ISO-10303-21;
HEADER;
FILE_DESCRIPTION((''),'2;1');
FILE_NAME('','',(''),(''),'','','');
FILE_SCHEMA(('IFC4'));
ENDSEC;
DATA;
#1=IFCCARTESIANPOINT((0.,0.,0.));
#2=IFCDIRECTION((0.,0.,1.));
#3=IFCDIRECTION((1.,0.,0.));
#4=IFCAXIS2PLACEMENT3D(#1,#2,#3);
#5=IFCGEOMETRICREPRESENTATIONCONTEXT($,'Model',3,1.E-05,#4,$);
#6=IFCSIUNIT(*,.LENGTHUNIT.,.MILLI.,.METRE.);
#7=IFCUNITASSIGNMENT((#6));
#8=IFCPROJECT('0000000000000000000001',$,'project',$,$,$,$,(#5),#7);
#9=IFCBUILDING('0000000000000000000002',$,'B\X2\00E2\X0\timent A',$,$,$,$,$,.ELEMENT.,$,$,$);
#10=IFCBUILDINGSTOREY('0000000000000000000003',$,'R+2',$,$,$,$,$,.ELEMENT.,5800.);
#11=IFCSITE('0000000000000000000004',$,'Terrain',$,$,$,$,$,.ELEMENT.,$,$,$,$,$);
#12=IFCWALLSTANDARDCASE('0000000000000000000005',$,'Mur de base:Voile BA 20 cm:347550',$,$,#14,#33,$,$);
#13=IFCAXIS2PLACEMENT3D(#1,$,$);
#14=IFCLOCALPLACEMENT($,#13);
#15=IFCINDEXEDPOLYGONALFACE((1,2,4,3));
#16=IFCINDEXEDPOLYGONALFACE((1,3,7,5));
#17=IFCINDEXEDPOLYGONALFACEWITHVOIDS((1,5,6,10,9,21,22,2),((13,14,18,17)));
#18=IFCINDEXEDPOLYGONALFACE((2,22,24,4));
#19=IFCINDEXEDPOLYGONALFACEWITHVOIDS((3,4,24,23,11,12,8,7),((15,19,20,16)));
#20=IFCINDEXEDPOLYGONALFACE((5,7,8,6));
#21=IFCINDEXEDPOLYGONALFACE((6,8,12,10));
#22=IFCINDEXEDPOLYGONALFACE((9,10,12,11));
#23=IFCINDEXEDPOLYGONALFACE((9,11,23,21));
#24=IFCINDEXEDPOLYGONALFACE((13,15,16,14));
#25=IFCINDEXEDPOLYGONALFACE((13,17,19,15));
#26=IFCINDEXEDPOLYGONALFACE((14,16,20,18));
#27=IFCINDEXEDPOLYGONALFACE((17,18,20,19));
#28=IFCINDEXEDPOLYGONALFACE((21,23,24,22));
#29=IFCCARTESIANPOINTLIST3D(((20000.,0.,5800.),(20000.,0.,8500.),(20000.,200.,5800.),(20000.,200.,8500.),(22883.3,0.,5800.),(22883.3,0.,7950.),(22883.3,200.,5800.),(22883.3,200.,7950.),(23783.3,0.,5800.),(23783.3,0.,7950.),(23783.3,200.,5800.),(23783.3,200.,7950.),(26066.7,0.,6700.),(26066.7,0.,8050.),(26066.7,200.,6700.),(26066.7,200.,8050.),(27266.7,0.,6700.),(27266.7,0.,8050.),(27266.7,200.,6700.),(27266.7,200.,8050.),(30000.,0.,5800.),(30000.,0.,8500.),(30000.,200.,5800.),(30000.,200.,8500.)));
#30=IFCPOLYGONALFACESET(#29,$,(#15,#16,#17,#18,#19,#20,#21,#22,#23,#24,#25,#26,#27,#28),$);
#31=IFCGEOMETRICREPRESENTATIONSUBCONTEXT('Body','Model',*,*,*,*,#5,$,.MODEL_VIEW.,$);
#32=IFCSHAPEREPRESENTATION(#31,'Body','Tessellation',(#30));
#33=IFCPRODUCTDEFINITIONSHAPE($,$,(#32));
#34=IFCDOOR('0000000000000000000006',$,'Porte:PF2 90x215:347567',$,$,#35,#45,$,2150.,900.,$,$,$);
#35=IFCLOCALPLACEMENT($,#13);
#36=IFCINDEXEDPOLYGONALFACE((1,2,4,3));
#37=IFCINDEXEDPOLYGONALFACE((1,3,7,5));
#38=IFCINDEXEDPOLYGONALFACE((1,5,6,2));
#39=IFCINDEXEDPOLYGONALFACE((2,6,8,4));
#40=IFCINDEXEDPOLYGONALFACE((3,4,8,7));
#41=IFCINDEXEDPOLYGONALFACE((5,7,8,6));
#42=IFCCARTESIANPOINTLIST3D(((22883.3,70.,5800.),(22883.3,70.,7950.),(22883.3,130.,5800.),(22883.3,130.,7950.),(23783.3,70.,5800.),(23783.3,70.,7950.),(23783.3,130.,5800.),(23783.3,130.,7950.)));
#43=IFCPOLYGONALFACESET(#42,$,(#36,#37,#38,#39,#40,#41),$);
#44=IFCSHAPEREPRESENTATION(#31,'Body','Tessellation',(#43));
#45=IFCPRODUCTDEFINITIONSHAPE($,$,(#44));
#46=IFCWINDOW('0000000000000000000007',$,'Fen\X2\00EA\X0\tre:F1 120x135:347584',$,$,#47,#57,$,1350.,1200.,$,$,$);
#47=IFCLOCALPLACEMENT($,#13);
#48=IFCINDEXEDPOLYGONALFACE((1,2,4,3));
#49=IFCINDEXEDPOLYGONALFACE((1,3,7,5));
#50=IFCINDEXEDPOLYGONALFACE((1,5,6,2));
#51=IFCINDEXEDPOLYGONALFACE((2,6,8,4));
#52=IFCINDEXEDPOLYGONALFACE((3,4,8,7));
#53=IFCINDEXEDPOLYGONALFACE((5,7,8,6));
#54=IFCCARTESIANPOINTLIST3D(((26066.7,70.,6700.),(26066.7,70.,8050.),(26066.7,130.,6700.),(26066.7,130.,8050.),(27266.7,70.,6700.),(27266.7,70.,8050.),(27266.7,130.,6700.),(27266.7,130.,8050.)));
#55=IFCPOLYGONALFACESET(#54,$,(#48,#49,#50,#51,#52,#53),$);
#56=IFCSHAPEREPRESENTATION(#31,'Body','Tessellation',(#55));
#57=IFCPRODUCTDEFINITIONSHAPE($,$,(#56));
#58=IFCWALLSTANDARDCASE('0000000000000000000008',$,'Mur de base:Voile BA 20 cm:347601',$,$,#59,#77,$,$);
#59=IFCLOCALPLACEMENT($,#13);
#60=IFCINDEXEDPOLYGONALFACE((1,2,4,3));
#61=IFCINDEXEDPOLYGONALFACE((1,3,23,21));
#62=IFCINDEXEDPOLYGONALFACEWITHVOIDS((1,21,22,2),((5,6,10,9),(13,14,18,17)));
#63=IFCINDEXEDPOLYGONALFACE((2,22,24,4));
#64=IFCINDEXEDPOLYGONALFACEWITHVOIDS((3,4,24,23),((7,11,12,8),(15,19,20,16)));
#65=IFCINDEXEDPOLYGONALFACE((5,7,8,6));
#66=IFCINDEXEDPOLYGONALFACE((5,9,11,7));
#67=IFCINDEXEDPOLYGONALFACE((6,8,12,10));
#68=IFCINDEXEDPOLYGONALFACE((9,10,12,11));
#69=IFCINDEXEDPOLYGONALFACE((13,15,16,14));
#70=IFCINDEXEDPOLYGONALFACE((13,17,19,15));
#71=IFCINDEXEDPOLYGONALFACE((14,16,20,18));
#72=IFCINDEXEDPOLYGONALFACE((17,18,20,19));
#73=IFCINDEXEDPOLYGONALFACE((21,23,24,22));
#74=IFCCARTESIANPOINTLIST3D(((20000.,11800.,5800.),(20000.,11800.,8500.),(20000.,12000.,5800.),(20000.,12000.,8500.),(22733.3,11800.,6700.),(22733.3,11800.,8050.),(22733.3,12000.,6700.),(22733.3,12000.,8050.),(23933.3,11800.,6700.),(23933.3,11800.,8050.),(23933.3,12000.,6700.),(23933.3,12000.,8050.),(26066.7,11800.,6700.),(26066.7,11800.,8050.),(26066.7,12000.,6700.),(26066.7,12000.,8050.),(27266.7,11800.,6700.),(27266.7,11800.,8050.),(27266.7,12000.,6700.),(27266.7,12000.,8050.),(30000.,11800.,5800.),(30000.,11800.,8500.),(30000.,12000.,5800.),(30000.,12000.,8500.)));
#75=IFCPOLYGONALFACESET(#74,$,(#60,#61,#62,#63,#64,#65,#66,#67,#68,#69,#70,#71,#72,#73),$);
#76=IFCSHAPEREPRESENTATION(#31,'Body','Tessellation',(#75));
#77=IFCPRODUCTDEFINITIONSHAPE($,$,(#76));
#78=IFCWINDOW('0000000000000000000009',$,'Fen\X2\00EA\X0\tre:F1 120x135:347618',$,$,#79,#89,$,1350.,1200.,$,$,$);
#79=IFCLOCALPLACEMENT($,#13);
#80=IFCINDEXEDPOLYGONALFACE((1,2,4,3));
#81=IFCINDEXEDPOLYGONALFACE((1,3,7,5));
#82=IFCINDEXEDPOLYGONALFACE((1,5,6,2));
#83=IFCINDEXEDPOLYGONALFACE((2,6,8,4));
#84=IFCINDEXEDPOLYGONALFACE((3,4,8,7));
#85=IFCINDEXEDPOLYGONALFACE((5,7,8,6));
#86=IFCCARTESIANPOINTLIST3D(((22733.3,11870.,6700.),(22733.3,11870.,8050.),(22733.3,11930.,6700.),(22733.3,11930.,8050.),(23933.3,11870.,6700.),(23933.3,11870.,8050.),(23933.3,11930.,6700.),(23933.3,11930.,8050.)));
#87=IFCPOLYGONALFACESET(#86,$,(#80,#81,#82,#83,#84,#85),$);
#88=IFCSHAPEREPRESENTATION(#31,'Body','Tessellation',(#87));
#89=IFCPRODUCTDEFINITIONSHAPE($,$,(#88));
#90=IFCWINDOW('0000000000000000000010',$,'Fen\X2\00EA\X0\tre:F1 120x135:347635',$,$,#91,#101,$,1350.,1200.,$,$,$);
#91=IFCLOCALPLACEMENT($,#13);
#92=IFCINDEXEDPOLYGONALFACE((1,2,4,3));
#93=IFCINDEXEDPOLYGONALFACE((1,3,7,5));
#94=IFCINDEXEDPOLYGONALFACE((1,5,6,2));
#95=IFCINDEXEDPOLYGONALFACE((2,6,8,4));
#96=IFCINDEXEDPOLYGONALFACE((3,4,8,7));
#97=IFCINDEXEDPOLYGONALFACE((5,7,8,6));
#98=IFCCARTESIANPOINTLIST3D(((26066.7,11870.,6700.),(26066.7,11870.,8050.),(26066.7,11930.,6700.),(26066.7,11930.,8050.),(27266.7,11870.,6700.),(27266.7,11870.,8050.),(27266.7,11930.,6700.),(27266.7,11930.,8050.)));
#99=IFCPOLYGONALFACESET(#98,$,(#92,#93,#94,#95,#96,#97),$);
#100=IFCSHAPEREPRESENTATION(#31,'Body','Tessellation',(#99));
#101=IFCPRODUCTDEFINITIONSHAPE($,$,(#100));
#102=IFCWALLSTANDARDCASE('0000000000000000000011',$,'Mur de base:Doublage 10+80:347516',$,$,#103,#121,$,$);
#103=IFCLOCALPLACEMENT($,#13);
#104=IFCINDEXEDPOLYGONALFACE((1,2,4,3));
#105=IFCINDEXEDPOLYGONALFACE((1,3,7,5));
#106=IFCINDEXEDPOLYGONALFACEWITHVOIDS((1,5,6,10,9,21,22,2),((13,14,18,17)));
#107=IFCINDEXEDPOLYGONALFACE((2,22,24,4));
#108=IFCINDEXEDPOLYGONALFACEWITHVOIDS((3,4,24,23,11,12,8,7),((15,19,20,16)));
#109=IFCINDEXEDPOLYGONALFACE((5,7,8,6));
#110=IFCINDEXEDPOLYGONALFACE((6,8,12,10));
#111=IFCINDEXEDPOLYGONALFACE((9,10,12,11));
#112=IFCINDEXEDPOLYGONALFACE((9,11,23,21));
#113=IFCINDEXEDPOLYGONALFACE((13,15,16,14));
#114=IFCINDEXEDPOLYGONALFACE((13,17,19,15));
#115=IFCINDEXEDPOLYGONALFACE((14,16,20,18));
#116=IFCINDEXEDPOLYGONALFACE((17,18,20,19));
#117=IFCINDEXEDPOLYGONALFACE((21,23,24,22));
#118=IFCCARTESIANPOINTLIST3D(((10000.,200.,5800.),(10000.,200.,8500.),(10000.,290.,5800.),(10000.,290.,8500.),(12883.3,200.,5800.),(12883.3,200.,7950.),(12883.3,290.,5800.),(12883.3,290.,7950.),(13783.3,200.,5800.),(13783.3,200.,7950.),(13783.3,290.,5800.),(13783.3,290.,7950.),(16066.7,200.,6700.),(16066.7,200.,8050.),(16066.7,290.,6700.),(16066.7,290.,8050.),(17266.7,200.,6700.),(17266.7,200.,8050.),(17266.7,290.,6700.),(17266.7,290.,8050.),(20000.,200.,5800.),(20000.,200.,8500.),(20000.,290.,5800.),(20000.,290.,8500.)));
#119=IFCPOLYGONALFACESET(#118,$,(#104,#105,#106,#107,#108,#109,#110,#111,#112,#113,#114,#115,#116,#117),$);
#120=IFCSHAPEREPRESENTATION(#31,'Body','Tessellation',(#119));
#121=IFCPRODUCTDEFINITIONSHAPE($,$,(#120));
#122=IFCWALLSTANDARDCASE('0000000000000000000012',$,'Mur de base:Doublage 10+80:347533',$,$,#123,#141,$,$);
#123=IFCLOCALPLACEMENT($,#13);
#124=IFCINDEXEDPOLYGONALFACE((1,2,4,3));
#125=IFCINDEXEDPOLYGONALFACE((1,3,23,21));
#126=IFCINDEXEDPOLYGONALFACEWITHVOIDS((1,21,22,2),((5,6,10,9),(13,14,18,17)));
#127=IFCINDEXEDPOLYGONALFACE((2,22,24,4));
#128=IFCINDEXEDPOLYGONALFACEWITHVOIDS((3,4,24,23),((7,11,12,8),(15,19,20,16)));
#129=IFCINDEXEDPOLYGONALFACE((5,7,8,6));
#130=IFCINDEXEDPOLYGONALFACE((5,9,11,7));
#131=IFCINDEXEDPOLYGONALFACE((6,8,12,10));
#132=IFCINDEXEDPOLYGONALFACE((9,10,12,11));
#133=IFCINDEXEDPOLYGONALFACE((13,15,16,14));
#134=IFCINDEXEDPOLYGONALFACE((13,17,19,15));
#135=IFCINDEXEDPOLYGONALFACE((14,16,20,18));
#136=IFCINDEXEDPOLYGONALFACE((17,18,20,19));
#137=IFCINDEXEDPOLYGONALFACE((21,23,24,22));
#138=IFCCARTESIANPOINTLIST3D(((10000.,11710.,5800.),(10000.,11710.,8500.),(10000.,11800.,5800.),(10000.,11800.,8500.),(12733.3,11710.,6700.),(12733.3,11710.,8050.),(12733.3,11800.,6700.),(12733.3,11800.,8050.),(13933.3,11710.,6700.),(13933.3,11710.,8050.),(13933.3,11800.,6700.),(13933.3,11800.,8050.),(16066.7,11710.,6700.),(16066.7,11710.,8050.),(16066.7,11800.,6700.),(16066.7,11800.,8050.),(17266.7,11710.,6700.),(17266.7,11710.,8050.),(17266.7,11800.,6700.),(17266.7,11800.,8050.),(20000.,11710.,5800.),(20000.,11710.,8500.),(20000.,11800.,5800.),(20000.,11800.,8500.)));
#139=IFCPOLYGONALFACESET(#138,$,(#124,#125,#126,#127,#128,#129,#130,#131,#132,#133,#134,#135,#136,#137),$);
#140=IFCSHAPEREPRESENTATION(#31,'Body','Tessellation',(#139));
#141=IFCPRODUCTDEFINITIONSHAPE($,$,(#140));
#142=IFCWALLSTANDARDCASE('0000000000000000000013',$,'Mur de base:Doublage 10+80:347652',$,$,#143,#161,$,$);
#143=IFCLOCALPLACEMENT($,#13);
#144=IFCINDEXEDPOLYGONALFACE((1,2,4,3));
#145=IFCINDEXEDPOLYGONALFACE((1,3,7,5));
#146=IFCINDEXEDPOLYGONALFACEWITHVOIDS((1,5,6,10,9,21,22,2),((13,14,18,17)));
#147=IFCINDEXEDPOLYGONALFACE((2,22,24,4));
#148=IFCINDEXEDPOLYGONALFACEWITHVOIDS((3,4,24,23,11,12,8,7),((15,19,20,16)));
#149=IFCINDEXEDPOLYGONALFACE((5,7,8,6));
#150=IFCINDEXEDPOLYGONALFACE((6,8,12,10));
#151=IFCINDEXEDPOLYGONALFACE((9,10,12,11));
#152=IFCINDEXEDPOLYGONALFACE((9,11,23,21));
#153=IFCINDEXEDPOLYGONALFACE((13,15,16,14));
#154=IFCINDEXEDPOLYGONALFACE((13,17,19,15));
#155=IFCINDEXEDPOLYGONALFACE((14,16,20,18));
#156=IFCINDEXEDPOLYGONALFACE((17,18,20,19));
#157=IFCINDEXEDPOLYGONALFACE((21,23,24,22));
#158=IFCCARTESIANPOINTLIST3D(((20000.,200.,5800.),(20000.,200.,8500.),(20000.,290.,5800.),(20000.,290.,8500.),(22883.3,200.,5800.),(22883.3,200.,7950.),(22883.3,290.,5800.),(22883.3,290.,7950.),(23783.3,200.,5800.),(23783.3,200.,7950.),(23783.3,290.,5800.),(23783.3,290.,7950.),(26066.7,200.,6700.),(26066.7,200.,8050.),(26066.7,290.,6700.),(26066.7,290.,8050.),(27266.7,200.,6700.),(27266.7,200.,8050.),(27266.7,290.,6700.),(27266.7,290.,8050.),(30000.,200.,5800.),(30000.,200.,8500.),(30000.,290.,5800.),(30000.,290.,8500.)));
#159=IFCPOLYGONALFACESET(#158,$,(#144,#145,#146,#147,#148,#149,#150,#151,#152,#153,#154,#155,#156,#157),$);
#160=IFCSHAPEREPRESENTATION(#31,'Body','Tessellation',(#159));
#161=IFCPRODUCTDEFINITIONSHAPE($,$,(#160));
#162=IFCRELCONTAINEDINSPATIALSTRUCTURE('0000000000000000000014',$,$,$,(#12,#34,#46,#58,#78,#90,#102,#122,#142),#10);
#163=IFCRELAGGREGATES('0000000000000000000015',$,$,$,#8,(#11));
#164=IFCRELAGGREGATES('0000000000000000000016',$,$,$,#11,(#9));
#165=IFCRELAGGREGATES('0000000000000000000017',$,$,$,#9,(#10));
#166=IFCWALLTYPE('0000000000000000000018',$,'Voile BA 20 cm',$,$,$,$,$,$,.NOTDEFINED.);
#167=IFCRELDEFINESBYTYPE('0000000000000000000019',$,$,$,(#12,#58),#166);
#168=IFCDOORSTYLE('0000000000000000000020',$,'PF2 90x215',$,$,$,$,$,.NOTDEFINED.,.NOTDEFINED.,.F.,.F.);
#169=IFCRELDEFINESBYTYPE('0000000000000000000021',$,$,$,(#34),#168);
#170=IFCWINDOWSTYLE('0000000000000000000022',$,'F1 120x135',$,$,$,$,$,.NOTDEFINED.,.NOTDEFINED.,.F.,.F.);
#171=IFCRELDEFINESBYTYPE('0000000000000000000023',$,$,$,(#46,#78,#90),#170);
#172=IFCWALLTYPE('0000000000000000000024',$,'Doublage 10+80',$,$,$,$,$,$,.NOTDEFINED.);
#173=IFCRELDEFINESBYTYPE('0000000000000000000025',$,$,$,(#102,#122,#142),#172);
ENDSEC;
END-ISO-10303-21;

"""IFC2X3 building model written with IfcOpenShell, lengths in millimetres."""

from ifc_helpers import new_model, si_unit, frame, frame_2d, origin_with_axes, place, context, subcontext, project, spatial, rectangle, extrude, type_object, element, fill, save


model = new_model("IFC2X3")

# Units and contexts
model_context = context("Model", 3, precision=1e-05, world=origin_with_axes())
body_context = subcontext(model_context, "Body", "Model", "MODEL_VIEW")
ifc_project = project(units=[si_unit("LENGTHUNIT", "METRE", prefix="MILLI")], contexts=[model_context])

# Site, building, storey
site = spatial("IfcSite", under=ifc_project, Name="Terrain", CompositionType="ELEMENT")
building = spatial("IfcBuilding", under=site, Name="Bâtiment A", CompositionType="ELEMENT")
storey = spatial("IfcBuildingStorey", under=building, Name="R+2", CompositionType="ELEMENT", Elevation=5800.0)

# Wall, openings, door, window
wall_type_1 = type_object("IfcWallType", Name="Voile BA 20 cm", PredefinedType="NOTDEFINED")
wall_1_placement = place(None, origin_with_axes())
wall_1 = element("IfcWallStandardCase", 1, at=wall_1_placement, inside=storey, type_object=wall_type_1, Name="Mur de base:Voile BA 20 cm:347550", context=body_context, shape_type="SweptSolid", body=[
    extrude(rectangle(XDim=10000.0, YDim=200.0, at=frame_2d((25000.0, 100.0))), frame((0.0, 0.0, 5800.0), z_axis=(0.0, 0.0, 1.0), x_axis=(1.0, 0.0, 0.0)), (0.0, 0.0, 1.0), 2700.0),
])
opening_1_placement = place(None, origin_with_axes())
opening_1 = element("IfcOpeningElement", 2, at=opening_1_placement, cuts=wall_1, context=body_context, shape_type="SweptSolid", body=[
    extrude(rectangle(XDim=900.0, YDim=320.0, at=frame_2d((23333.3, 100.0))), frame((0.0, 0.0, 5800.0), z_axis=(0.0, 0.0, 1.0), x_axis=(1.0, 0.0, 0.0)), (0.0, 0.0, 1.0), 2150.0),
])
opening_2_placement = place(None, origin_with_axes())
opening_2 = element("IfcOpeningElement", 3, at=opening_2_placement, cuts=wall_1, context=body_context, shape_type="SweptSolid", body=[
    extrude(rectangle(XDim=1200.0, YDim=320.0, at=frame_2d((26666.7, 100.0))), frame((0.0, 0.0, 6700.0), z_axis=(0.0, 0.0, 1.0), x_axis=(1.0, 0.0, 0.0)), (0.0, 0.0, 1.0), 1350.0),
])
door_style = type_object("IfcDoorStyle", Name="PF2 90x215", ConstructionType="NOTDEFINED", OperationType="NOTDEFINED", ParameterTakesPrecedence=False, Sizeable=False)
door_placement = place(None, origin_with_axes())
door = element("IfcDoor", 4, at=door_placement, inside=storey, type_object=door_style, Name="Porte:PF2 90x215:347567", OverallHeight=2150.0, OverallWidth=900.0, context=body_context, shape_type="SweptSolid", body=[
    extrude(rectangle(XDim=900.0, YDim=60.0, at=frame_2d((23333.3, 100.0))), frame((0.0, 0.0, 5800.0), z_axis=(0.0, 0.0, 1.0), x_axis=(1.0, 0.0, 0.0)), (0.0, 0.0, 1.0), 2150.0),
])
fill(opening_1, door)
window_style = type_object("IfcWindowStyle", Name="F1 120x135", ConstructionType="NOTDEFINED", OperationType="NOTDEFINED", ParameterTakesPrecedence=False, Sizeable=False)
window_1_placement = place(None, origin_with_axes())
window_1 = element("IfcWindow", 5, at=window_1_placement, inside=storey, type_object=window_style, Name="Fenêtre:F1 120x135:347584", OverallHeight=1350.0, OverallWidth=1200.0, context=body_context, shape_type="SweptSolid", body=[
    extrude(rectangle(XDim=1200.0, YDim=60.0, at=frame_2d((26666.7, 100.0))), frame((0.0, 0.0, 6700.0), z_axis=(0.0, 0.0, 1.0), x_axis=(1.0, 0.0, 0.0)), (0.0, 0.0, 1.0), 1350.0),
])
fill(opening_2, window_1)

# Wall, openings, windows
wall_2_placement = place(None, origin_with_axes())
wall_2 = element("IfcWallStandardCase", 6, at=wall_2_placement, inside=storey, type_object=wall_type_1, Name="Mur de base:Voile BA 20 cm:347601", context=body_context, shape_type="SweptSolid", body=[
    extrude(rectangle(XDim=10000.0, YDim=200.0, at=frame_2d((25000.0, 11900.0))), frame((0.0, 0.0, 5800.0), z_axis=(0.0, 0.0, 1.0), x_axis=(1.0, 0.0, 0.0)), (0.0, 0.0, 1.0), 2700.0),
])
opening_3_placement = place(None, origin_with_axes())
opening_3 = element("IfcOpeningElement", 7, at=opening_3_placement, cuts=wall_2, context=body_context, shape_type="SweptSolid", body=[
    extrude(rectangle(XDim=1200.0, YDim=320.0, at=frame_2d((23333.3, 11900.0))), frame((0.0, 0.0, 6700.0), z_axis=(0.0, 0.0, 1.0), x_axis=(1.0, 0.0, 0.0)), (0.0, 0.0, 1.0), 1350.0),
])
opening_4_placement = place(None, origin_with_axes())
opening_4 = element("IfcOpeningElement", 8, at=opening_4_placement, cuts=wall_2, context=body_context, shape_type="SweptSolid", body=[
    extrude(rectangle(XDim=1200.0, YDim=320.0, at=frame_2d((26666.7, 11900.0))), frame((0.0, 0.0, 6700.0), z_axis=(0.0, 0.0, 1.0), x_axis=(1.0, 0.0, 0.0)), (0.0, 0.0, 1.0), 1350.0),
])
window_2_placement = place(None, origin_with_axes())
window_2 = element("IfcWindow", 9, at=window_2_placement, inside=storey, type_object=window_style, Name="Fenêtre:F1 120x135:347618", OverallHeight=1350.0, OverallWidth=1200.0, context=body_context, shape_type="SweptSolid", body=[
    extrude(rectangle(XDim=1200.0, YDim=60.0, at=frame_2d((23333.3, 11900.0))), frame((0.0, 0.0, 6700.0), z_axis=(0.0, 0.0, 1.0), x_axis=(1.0, 0.0, 0.0)), (0.0, 0.0, 1.0), 1350.0),
])
fill(opening_3, window_2)
window_3_placement = place(None, origin_with_axes())
window_3 = element("IfcWindow", 10, at=window_3_placement, inside=storey, type_object=window_style, Name="Fenêtre:F1 120x135:347635", OverallHeight=1350.0, OverallWidth=1200.0, context=body_context, shape_type="SweptSolid", body=[
    extrude(rectangle(XDim=1200.0, YDim=60.0, at=frame_2d((26666.7, 11900.0))), frame((0.0, 0.0, 6700.0), z_axis=(0.0, 0.0, 1.0), x_axis=(1.0, 0.0, 0.0)), (0.0, 0.0, 1.0), 1350.0),
])
fill(opening_4, window_3)

# Walls, openings
wall_type_2 = type_object("IfcWallType", Name="Doublage 10+80", PredefinedType="NOTDEFINED")
wall_3_placement = place(None, origin_with_axes())
wall_3 = element("IfcWallStandardCase", 11, at=wall_3_placement, inside=storey, type_object=wall_type_2, Name="Mur de base:Doublage 10+80:347516", context=body_context, shape_type="SweptSolid", body=[
    extrude(rectangle(XDim=10000.0, YDim=90.0, at=frame_2d((15000.0, 245.0))), frame((0.0, 0.0, 5800.0), z_axis=(0.0, 0.0, 1.0), x_axis=(1.0, 0.0, 0.0)), (0.0, 0.0, 1.0), 2700.0),
])
opening_5_placement = place(None, origin_with_axes())
element("IfcOpeningElement", 12, at=opening_5_placement, cuts=wall_3, context=body_context, shape_type="SweptSolid", body=[
    extrude(rectangle(XDim=900.0, YDim=210.0, at=frame_2d((13333.3, 245.0))), frame((0.0, 0.0, 5800.0), z_axis=(0.0, 0.0, 1.0), x_axis=(1.0, 0.0, 0.0)), (0.0, 0.0, 1.0), 2150.0),
])
opening_6_placement = place(None, origin_with_axes())
element("IfcOpeningElement", 13, at=opening_6_placement, cuts=wall_3, context=body_context, shape_type="SweptSolid", body=[
    extrude(rectangle(XDim=1200.0, YDim=210.0, at=frame_2d((16666.7, 245.0))), frame((0.0, 0.0, 6700.0), z_axis=(0.0, 0.0, 1.0), x_axis=(1.0, 0.0, 0.0)), (0.0, 0.0, 1.0), 1350.0),
])
wall_4_placement = place(None, origin_with_axes())
wall_4 = element("IfcWallStandardCase", 14, at=wall_4_placement, inside=storey, type_object=wall_type_2, Name="Mur de base:Doublage 10+80:347533", context=body_context, shape_type="SweptSolid", body=[
    extrude(rectangle(XDim=10000.0, YDim=90.0, at=frame_2d((15000.0, 11755.0))), frame((0.0, 0.0, 5800.0), z_axis=(0.0, 0.0, 1.0), x_axis=(1.0, 0.0, 0.0)), (0.0, 0.0, 1.0), 2700.0),
])
opening_7_placement = place(None, origin_with_axes())
element("IfcOpeningElement", 15, at=opening_7_placement, cuts=wall_4, context=body_context, shape_type="SweptSolid", body=[
    extrude(rectangle(XDim=1200.0, YDim=210.0, at=frame_2d((13333.3, 11755.0))), frame((0.0, 0.0, 6700.0), z_axis=(0.0, 0.0, 1.0), x_axis=(1.0, 0.0, 0.0)), (0.0, 0.0, 1.0), 1350.0),
])
opening_8_placement = place(None, origin_with_axes())
element("IfcOpeningElement", 16, at=opening_8_placement, cuts=wall_4, context=body_context, shape_type="SweptSolid", body=[
    extrude(rectangle(XDim=1200.0, YDim=210.0, at=frame_2d((16666.7, 11755.0))), frame((0.0, 0.0, 6700.0), z_axis=(0.0, 0.0, 1.0), x_axis=(1.0, 0.0, 0.0)), (0.0, 0.0, 1.0), 1350.0),
])
wall_5_placement = place(None, origin_with_axes())
wall_5 = element("IfcWallStandardCase", 17, at=wall_5_placement, inside=storey, type_object=wall_type_2, Name="Mur de base:Doublage 10+80:347652", context=body_context, shape_type="SweptSolid", body=[
    extrude(rectangle(XDim=10000.0, YDim=90.0, at=frame_2d((25000.0, 245.0))), frame((0.0, 0.0, 5800.0), z_axis=(0.0, 0.0, 1.0), x_axis=(1.0, 0.0, 0.0)), (0.0, 0.0, 1.0), 2700.0),
])
opening_9_placement = place(None, origin_with_axes())
element("IfcOpeningElement", 18, at=opening_9_placement, cuts=wall_5, context=body_context, shape_type="SweptSolid", body=[
    extrude(rectangle(XDim=900.0, YDim=210.0, at=frame_2d((23333.3, 245.0))), frame((0.0, 0.0, 5800.0), z_axis=(0.0, 0.0, 1.0), x_axis=(1.0, 0.0, 0.0)), (0.0, 0.0, 1.0), 2150.0),
])
opening_10_placement = place(None, origin_with_axes())
element("IfcOpeningElement", 19, at=opening_10_placement, cuts=wall_5, context=body_context, shape_type="SweptSolid", body=[
    extrude(rectangle(XDim=1200.0, YDim=210.0, at=frame_2d((26666.7, 245.0))), frame((0.0, 0.0, 6700.0), z_axis=(0.0, 0.0, 1.0), x_axis=(1.0, 0.0, 0.0)), (0.0, 0.0, 1.0), 1350.0),
])

save(model, "model.ifc")
